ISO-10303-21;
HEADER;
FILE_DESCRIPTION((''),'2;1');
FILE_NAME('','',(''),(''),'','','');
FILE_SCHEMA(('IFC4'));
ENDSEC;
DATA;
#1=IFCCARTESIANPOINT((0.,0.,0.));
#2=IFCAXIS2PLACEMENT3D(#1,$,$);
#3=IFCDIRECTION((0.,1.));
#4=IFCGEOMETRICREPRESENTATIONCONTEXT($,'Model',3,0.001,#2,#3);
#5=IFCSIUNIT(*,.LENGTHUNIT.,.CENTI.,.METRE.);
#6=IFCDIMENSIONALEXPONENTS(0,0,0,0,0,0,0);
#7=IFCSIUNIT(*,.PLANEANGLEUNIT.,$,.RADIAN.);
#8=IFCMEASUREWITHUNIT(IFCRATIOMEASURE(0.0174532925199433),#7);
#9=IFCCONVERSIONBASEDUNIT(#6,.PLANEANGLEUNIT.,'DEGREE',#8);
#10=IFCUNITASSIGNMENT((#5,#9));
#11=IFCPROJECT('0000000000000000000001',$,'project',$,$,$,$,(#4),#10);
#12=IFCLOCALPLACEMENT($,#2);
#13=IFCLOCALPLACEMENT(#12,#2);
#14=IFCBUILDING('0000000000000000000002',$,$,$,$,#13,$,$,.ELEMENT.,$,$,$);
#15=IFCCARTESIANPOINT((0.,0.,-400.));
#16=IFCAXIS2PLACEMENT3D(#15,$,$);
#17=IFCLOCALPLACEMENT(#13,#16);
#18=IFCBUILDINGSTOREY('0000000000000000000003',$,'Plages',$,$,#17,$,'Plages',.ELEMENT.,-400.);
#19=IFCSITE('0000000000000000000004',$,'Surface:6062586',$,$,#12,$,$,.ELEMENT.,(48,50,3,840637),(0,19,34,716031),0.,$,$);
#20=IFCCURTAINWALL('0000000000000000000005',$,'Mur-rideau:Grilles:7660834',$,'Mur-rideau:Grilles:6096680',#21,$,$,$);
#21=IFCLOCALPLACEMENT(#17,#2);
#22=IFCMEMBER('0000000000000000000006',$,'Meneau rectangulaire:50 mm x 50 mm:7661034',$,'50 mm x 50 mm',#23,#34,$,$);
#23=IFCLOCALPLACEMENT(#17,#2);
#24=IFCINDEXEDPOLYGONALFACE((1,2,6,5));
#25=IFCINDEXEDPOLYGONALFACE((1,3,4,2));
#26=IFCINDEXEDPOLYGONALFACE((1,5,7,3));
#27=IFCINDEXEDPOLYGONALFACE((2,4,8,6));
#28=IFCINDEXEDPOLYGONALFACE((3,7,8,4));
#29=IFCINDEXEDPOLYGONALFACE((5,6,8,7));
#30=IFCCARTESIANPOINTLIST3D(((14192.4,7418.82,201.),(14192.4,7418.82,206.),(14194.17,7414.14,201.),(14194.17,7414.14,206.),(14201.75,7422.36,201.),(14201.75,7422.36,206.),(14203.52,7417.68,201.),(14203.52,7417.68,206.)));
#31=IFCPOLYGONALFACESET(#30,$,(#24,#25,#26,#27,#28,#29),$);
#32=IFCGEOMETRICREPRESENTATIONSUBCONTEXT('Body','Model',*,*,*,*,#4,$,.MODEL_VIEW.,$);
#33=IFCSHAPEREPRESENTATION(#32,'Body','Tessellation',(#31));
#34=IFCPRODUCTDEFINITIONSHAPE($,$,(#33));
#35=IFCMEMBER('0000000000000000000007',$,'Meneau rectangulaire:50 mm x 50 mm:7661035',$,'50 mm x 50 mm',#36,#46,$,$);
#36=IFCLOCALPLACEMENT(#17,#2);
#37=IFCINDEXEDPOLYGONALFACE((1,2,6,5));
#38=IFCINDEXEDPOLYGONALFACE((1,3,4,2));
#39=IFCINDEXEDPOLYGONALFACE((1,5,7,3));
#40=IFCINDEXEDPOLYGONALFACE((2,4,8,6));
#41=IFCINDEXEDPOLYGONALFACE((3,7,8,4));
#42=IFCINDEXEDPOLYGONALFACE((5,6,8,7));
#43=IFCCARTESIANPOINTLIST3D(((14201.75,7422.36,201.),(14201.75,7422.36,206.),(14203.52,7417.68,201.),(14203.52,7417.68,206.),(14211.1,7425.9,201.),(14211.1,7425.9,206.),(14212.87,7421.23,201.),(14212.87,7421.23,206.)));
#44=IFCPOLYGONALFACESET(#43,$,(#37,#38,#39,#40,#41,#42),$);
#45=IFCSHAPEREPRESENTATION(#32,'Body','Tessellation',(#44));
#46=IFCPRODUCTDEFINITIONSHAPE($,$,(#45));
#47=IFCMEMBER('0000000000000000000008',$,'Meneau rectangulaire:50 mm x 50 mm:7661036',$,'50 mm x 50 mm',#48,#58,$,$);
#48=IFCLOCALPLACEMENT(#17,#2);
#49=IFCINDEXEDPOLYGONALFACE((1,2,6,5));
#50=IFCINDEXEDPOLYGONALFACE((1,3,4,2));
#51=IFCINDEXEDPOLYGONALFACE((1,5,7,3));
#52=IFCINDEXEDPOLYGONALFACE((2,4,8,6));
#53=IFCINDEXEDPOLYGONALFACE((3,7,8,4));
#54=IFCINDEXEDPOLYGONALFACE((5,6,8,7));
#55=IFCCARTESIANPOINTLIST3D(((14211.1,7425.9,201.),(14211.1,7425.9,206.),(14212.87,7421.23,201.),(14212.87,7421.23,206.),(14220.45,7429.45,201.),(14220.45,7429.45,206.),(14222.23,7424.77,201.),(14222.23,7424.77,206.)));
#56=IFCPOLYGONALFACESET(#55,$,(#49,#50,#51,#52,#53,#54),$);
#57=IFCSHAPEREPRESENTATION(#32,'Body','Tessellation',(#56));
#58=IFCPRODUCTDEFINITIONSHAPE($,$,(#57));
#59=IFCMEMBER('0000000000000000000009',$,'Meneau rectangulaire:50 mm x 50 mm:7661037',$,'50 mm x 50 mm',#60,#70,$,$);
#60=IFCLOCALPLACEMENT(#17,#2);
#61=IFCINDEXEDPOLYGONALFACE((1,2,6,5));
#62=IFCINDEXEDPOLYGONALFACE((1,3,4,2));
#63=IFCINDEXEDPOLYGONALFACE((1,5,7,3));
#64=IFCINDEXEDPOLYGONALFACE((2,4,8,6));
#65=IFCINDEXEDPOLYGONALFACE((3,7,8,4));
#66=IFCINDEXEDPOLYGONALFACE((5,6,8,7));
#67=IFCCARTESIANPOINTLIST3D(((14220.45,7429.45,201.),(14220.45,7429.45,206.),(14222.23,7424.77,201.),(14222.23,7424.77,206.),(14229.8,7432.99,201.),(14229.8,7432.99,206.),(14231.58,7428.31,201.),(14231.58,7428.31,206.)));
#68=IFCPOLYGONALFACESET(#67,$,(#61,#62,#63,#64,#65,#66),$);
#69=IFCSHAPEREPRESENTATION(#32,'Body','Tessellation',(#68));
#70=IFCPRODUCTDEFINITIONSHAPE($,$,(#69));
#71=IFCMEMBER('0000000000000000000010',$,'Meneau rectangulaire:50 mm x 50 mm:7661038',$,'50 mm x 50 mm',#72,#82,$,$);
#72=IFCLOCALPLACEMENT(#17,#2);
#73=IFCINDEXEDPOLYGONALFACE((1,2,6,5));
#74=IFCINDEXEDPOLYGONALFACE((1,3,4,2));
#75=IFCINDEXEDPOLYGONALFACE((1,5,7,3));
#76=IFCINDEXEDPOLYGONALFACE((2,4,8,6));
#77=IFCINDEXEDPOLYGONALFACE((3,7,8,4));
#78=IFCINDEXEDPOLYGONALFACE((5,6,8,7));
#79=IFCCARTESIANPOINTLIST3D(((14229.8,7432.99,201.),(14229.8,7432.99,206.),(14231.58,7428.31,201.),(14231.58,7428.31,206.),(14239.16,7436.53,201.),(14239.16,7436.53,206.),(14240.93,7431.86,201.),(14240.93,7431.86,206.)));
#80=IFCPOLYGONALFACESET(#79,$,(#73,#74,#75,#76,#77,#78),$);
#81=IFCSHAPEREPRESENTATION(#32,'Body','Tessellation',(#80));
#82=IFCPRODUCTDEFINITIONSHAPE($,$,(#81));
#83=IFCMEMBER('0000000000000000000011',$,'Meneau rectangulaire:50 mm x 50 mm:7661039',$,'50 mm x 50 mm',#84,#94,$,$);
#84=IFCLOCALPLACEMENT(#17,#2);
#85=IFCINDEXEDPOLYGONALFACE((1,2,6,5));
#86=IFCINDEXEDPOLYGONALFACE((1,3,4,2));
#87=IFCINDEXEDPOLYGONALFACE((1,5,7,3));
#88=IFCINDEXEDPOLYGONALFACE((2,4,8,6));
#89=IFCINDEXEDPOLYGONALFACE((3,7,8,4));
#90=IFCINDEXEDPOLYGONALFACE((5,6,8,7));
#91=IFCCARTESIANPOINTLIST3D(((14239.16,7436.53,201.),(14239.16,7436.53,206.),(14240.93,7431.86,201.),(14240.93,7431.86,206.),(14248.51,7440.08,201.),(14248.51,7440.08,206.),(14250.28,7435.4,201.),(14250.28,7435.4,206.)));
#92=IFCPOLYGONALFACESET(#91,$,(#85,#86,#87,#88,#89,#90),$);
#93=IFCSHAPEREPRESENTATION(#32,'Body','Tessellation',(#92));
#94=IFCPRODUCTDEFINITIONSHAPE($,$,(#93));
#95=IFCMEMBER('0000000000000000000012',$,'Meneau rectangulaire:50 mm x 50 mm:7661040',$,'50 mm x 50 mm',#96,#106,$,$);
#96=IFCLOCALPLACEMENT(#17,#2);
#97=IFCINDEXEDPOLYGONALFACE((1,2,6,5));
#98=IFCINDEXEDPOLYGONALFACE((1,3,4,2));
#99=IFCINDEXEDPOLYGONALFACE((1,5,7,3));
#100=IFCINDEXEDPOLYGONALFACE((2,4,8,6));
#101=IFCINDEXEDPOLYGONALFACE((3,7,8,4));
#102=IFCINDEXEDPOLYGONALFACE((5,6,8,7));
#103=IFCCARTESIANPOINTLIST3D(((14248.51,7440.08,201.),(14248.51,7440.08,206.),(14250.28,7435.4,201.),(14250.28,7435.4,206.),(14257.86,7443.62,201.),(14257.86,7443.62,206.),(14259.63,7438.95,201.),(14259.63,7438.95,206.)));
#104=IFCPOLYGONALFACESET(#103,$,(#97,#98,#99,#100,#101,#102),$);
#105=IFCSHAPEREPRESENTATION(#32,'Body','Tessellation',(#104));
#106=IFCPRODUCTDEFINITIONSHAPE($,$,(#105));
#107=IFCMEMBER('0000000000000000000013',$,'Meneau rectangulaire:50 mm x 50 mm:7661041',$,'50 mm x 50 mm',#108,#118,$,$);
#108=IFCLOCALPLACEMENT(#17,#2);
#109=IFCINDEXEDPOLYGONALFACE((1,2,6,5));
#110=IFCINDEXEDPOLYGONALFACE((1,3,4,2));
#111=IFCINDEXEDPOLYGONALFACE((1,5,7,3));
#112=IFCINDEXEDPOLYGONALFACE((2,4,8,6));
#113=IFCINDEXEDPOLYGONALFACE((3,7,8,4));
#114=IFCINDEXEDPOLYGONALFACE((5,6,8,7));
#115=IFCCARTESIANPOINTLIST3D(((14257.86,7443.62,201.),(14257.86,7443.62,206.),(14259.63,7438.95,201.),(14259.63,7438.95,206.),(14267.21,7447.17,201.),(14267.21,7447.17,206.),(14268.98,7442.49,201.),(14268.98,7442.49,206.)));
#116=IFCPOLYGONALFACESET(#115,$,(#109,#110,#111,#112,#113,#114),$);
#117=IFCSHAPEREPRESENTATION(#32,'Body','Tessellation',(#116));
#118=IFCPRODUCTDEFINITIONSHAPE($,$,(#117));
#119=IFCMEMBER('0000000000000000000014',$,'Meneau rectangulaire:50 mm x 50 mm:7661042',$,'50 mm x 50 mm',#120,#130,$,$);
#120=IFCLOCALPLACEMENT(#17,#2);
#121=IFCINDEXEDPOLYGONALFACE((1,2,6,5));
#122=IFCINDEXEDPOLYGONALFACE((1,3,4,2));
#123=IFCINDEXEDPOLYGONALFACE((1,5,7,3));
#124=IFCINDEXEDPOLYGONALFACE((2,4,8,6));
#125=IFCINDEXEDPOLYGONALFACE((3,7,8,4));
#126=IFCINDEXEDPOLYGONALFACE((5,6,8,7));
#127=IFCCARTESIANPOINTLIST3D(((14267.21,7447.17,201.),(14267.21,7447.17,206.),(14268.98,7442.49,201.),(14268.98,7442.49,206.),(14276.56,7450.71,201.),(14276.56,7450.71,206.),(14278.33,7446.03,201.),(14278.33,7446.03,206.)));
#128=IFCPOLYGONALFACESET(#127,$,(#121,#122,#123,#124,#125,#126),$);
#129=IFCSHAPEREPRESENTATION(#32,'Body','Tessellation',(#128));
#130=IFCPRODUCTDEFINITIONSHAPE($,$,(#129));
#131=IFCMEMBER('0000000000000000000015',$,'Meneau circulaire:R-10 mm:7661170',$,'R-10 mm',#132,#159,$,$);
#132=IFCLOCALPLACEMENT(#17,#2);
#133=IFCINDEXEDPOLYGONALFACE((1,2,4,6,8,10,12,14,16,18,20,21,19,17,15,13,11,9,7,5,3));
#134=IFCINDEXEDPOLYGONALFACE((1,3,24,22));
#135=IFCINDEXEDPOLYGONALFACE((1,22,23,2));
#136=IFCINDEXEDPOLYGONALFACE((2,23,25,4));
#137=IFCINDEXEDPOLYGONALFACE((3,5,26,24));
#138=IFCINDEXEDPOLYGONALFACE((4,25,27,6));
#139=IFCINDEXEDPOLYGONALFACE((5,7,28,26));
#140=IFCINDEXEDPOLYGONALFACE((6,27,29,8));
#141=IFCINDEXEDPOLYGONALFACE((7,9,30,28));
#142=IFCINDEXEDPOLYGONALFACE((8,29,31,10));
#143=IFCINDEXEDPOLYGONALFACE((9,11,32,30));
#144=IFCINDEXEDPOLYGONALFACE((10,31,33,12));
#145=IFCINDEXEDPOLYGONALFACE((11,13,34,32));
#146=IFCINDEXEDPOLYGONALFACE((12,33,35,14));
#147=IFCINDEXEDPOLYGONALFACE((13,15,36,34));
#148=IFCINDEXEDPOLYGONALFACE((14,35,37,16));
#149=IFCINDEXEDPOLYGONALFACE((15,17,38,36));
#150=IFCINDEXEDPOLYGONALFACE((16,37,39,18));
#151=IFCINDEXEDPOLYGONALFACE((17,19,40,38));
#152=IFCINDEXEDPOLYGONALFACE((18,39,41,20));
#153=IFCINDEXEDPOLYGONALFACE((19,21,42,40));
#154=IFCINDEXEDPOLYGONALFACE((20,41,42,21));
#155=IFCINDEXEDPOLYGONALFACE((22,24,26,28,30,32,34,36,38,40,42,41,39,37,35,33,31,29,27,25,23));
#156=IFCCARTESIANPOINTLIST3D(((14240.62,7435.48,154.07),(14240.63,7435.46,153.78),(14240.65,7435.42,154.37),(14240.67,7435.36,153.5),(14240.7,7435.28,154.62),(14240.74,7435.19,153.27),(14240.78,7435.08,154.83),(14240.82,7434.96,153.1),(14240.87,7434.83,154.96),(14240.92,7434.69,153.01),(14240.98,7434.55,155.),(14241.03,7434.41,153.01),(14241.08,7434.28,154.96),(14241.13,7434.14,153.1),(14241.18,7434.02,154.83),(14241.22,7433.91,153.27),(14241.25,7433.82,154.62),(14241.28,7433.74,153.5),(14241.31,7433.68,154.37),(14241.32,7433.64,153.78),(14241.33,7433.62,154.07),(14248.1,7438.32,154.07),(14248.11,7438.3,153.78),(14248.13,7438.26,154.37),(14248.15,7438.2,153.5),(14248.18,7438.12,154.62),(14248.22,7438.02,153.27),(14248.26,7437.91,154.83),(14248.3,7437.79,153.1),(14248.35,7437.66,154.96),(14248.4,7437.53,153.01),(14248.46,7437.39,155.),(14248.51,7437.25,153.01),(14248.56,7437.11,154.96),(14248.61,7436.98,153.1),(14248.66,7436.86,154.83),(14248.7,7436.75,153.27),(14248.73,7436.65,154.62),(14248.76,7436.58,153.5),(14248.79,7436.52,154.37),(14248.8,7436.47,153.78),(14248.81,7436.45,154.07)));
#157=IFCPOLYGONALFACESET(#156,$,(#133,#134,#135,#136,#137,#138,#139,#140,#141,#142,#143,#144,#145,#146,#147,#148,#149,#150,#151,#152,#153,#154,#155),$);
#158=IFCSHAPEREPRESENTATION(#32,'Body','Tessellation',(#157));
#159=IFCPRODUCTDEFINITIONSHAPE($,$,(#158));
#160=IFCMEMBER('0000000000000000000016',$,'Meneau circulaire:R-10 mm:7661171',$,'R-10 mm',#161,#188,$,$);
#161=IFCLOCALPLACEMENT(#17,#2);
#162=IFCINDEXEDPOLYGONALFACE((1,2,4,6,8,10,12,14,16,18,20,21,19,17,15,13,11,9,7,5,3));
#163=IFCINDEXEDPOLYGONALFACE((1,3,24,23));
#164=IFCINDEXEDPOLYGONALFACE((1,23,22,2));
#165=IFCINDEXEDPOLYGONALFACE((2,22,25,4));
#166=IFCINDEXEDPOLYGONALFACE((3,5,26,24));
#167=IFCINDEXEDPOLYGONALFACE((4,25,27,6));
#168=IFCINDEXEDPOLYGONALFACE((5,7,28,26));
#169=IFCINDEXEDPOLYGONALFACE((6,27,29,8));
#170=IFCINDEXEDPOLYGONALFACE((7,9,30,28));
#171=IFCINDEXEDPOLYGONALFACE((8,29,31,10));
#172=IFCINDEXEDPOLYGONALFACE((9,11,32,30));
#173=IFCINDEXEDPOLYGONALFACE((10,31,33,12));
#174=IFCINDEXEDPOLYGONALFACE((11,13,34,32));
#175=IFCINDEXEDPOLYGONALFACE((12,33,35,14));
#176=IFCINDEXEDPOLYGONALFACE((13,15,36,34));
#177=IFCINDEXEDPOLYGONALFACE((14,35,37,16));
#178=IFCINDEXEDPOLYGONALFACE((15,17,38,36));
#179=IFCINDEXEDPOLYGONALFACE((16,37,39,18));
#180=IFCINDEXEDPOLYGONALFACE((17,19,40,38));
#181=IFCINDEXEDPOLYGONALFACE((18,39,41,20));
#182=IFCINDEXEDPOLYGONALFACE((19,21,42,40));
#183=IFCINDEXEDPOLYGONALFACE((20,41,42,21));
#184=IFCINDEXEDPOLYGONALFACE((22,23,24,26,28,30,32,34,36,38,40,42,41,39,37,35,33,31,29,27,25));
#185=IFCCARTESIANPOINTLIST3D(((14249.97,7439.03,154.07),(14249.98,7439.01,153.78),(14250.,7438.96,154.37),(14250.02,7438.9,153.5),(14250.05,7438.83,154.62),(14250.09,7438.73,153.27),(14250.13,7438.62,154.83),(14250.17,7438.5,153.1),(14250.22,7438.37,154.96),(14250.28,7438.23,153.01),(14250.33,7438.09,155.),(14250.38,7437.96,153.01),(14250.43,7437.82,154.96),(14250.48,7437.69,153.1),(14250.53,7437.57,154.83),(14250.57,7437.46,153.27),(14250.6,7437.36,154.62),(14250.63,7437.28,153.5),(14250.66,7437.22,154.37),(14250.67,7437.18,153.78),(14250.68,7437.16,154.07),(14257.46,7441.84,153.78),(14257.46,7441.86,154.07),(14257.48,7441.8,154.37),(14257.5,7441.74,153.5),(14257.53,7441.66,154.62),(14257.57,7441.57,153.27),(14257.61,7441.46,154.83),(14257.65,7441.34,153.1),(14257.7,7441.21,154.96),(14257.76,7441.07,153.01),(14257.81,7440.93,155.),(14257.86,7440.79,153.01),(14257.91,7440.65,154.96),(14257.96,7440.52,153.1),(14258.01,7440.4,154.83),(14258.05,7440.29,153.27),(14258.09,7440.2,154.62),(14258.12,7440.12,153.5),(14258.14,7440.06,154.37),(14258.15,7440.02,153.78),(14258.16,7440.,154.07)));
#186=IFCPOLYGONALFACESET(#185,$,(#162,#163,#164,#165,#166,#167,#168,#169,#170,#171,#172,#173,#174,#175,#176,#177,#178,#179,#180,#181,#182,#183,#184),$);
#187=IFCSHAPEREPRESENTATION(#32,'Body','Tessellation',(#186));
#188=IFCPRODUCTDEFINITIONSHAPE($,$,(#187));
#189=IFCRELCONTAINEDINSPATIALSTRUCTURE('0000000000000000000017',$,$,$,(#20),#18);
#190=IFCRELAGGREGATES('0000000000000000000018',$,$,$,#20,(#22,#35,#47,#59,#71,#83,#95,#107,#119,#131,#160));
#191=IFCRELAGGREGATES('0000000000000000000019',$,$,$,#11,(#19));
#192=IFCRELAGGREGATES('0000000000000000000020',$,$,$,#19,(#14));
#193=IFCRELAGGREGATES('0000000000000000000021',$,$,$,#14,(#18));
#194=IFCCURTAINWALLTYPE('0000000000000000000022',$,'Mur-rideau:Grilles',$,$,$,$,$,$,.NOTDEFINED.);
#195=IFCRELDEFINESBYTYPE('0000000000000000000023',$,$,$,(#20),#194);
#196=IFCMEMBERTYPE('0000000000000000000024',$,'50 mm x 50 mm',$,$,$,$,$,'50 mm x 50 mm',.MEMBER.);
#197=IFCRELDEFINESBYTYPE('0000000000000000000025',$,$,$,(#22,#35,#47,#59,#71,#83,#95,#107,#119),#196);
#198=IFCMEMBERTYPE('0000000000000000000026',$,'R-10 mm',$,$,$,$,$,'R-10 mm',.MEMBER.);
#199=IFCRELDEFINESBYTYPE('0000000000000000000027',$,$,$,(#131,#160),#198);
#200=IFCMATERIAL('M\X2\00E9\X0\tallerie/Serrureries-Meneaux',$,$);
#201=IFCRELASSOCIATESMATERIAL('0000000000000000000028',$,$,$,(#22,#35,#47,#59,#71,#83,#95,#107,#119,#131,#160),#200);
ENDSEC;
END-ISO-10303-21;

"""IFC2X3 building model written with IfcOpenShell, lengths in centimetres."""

from ifc_helpers import new_model, entity, si_unit, converted_unit, direction, frame, frame_2d, origin, origin_2d_with_axis, place, context, subcontext, project, spatial, rectangle, circle, extrude, source, transform, mapped, material, type_object, type_shapes, element, aggregate, save


model = new_model("IFC2X3")

# Units and contexts
model_context = context("Model", 3, precision=0.001, world=origin(), true_north=direction((0.0, 1.0)))
body_context = subcontext(model_context, "Body", "Model", "MODEL_VIEW")
ifc_project = project(units=[si_unit("LENGTHUNIT", "METRE", prefix="CENTI"), converted_unit("PLANEANGLEUNIT", "DEGREE", entity("IfcRatioMeasure", 0.0174532925199433), si_unit("PLANEANGLEUNIT", "RADIAN"), dimensions=[0, 0, 0, 0, 0, 0, 0])], contexts=[model_context])

# Site, building, storey
site_placement = place(None, origin())
site = spatial("IfcSite", under=ifc_project, at=site_placement, Name="Surface:6062586", CompositionType="ELEMENT", RefLatitude=(48, 50, 3, 840637), RefLongitude=(0, 19, 34, 716031), RefElevation=0.0)
building_placement = place(site_placement, origin())
building = spatial("IfcBuilding", under=site, at=building_placement, CompositionType="ELEMENT")
storey_placement = place(building_placement, frame((0.0, 0.0, -400.0)))
storey = spatial("IfcBuildingStorey", under=building, at=storey_placement, Name="Plages", LongName="Plages", CompositionType="ELEMENT", Elevation=-400.0)

# Curtain wall, members
curtain_wall_type = type_object("IfcCurtainWallType", Name="Mur-rideau:Grilles", PredefinedType="NOTDEFINED")
curtain_wall_placement = place(storey_placement, frame((0.0, 0.0, 400.0)))
curtain_wall = element("IfcCurtainWall", 1, at=curtain_wall_placement, inside=storey, type_object=curtain_wall_type, Name="Mur-rideau:Grilles:7660834", ObjectType="Mur-rideau:Grilles:6096680")
ifc_material = material(Name="Métallerie/Serrureries-Meneaux")
member_type_1 = type_object("IfcMemberType", Name="50 mm x 50 mm", ElementType="50 mm x 50 mm", PredefinedType="MEMBER")
shared_shape_1 = source(origin(), body_context, "Body", "SweptSolid", [
    extrude(rectangle(XDim=5.0, YDim=5.0, at=origin_2d_with_axis()), frame((-2.5, 0.0, -10.0), z_axis=(0.0, 0.0, 1.0), x_axis=(0.0, -1.0, 0.0)), (0.0, 0.0, 1.0), 10.0),
])
type_shapes(member_type_1, [shared_shape_1])
member_1_placement = place(storey_placement, frame((14202.64, 7420.02, 206.0), z_axis=(0.935103, 0.354376, 0.0), x_axis=(0.0, 0.0, 1.0)))
member_1 = element("IfcMember", 2, at=member_1_placement, type_object=member_type_1, material=ifc_material, Name="Meneau rectangulaire:50 mm x 50 mm:7661034", ObjectType="50 mm x 50 mm", context=body_context, shape_type="MappedRepresentation", body=[
    mapped(shared_shape_1, transform((0.0, 0.0, 0.0), scale=1.0)),
])
member_2_placement = place(storey_placement, frame((14211.99, 7423.56, 206.0), z_axis=(0.935103, 0.354376, 0.0), x_axis=(0.0, 0.0, 1.0)))
member_2 = element("IfcMember", 3, at=member_2_placement, type_object=member_type_1, material=ifc_material, Name="Meneau rectangulaire:50 mm x 50 mm:7661035", ObjectType="50 mm x 50 mm", context=body_context, shape_type="MappedRepresentation", body=[
    mapped(shared_shape_1, transform((0.0, 0.0, 0.0), scale=1.0)),
])
member_3_placement = place(storey_placement, frame((14221.34, 7427.11, 206.0), z_axis=(0.935103, 0.354376, 0.0), x_axis=(0.0, 0.0, 1.0)))
member_3 = element("IfcMember", 4, at=member_3_placement, type_object=member_type_1, material=ifc_material, Name="Meneau rectangulaire:50 mm x 50 mm:7661036", ObjectType="50 mm x 50 mm", context=body_context, shape_type="MappedRepresentation", body=[
    mapped(shared_shape_1, transform((0.0, 0.0, 0.0), scale=1.0)),
])
member_4_placement = place(storey_placement, frame((14230.69, 7430.65, 206.0), z_axis=(0.935103, 0.354376, 0.0), x_axis=(0.0, 0.0, 1.0)))
member_4 = element("IfcMember", 5, at=member_4_placement, type_object=member_type_1, material=ifc_material, Name="Meneau rectangulaire:50 mm x 50 mm:7661037", ObjectType="50 mm x 50 mm", context=body_context, shape_type="MappedRepresentation", body=[
    mapped(shared_shape_1, transform((0.0, 0.0, 0.0), scale=1.0)),
])
member_5_placement = place(storey_placement, frame((14240.04, 7434.2, 206.0), z_axis=(0.935103, 0.354376, 0.0), x_axis=(0.0, 0.0, 1.0)))
member_5 = element("IfcMember", 6, at=member_5_placement, type_object=member_type_1, material=ifc_material, Name="Meneau rectangulaire:50 mm x 50 mm:7661038", ObjectType="50 mm x 50 mm", context=body_context, shape_type="MappedRepresentation", body=[
    mapped(shared_shape_1, transform((0.0, 0.0, 0.0), scale=1.0)),
])
member_6_placement = place(storey_placement, frame((14249.39, 7437.74, 206.0), z_axis=(0.935103, 0.354376, 0.0), x_axis=(0.0, 0.0, 1.0)))
member_6 = element("IfcMember", 7, at=member_6_placement, type_object=member_type_1, material=ifc_material, Name="Meneau rectangulaire:50 mm x 50 mm:7661039", ObjectType="50 mm x 50 mm", context=body_context, shape_type="MappedRepresentation", body=[
    mapped(shared_shape_1, transform((0.0, 0.0, 0.0), scale=1.0)),
])
member_7_placement = place(storey_placement, frame((14258.74, 7441.28, 206.0), z_axis=(0.935103, 0.354376, 0.0), x_axis=(0.0, 0.0, 1.0)))
member_7 = element("IfcMember", 8, at=member_7_placement, type_object=member_type_1, material=ifc_material, Name="Meneau rectangulaire:50 mm x 50 mm:7661040", ObjectType="50 mm x 50 mm", context=body_context, shape_type="MappedRepresentation", body=[
    mapped(shared_shape_1, transform((0.0, 0.0, 0.0), scale=1.0)),
])
member_8_placement = place(storey_placement, frame((14268.09, 7444.83, 206.0), z_axis=(0.935103, 0.354376, 0.0), x_axis=(0.0, 0.0, 1.0)))
member_8 = element("IfcMember", 9, at=member_8_placement, type_object=member_type_1, material=ifc_material, Name="Meneau rectangulaire:50 mm x 50 mm:7661041", ObjectType="50 mm x 50 mm", context=body_context, shape_type="MappedRepresentation", body=[
    mapped(shared_shape_1, transform((0.0, 0.0, 0.0), scale=1.0)),
])
member_9_placement = place(storey_placement, frame((14277.45, 7448.37, 206.0), z_axis=(0.935103, 0.354376, 0.0), x_axis=(0.0, 0.0, 1.0)))
member_9 = element("IfcMember", 10, at=member_9_placement, type_object=member_type_1, material=ifc_material, Name="Meneau rectangulaire:50 mm x 50 mm:7661042", ObjectType="50 mm x 50 mm", context=body_context, shape_type="MappedRepresentation", body=[
    mapped(shared_shape_1, transform((0.0, 0.0, 0.0), scale=1.0)),
])
member_type_2 = type_object("IfcMemberType", Name="R-10 mm", ElementType="R-10 mm", PredefinedType="MEMBER")
shared_shape_2 = source(origin(), body_context, "Body", "SweptSolid", [
    extrude(circle(Radius=1.0, at=frame_2d((0.0, 0.0), x_axis=(1.0, 0.0))), frame((0.0, 0.0, -8.0)), (0.0, 0.0, 1.0), 8.0),
])
type_shapes(member_type_2, [shared_shape_2])
member_10_placement = place(storey_placement, frame((14248.46, 7437.39, 154.0), z_axis=(0.935103, 0.354376, 0.0), x_axis=(0.0, 0.0, 1.0)))
member_10 = element("IfcMember", 11, at=member_10_placement, type_object=member_type_2, material=ifc_material, Name="Meneau circulaire:R-10 mm:7661170", ObjectType="R-10 mm", context=body_context, shape_type="MappedRepresentation", body=[
    mapped(shared_shape_2, transform((0.0, 0.0, 0.0), scale=1.0)),
])
member_11_placement = place(storey_placement, frame((14257.81, 7440.93, 154.0), z_axis=(0.935103, 0.354376, 0.0), x_axis=(0.0, 0.0, 1.0)))
member_11 = element("IfcMember", 12, at=member_11_placement, type_object=member_type_2, material=ifc_material, Name="Meneau circulaire:R-10 mm:7661171", ObjectType="R-10 mm", context=body_context, shape_type="MappedRepresentation", body=[
    mapped(shared_shape_2, transform((0.0, 0.0, 0.0), scale=1.0)),
])
aggregate(curtain_wall, [member_1, member_2, member_3, member_4, member_5, member_6, member_7, member_8, member_9, member_10, member_11])

save(model, "model.ifc")
